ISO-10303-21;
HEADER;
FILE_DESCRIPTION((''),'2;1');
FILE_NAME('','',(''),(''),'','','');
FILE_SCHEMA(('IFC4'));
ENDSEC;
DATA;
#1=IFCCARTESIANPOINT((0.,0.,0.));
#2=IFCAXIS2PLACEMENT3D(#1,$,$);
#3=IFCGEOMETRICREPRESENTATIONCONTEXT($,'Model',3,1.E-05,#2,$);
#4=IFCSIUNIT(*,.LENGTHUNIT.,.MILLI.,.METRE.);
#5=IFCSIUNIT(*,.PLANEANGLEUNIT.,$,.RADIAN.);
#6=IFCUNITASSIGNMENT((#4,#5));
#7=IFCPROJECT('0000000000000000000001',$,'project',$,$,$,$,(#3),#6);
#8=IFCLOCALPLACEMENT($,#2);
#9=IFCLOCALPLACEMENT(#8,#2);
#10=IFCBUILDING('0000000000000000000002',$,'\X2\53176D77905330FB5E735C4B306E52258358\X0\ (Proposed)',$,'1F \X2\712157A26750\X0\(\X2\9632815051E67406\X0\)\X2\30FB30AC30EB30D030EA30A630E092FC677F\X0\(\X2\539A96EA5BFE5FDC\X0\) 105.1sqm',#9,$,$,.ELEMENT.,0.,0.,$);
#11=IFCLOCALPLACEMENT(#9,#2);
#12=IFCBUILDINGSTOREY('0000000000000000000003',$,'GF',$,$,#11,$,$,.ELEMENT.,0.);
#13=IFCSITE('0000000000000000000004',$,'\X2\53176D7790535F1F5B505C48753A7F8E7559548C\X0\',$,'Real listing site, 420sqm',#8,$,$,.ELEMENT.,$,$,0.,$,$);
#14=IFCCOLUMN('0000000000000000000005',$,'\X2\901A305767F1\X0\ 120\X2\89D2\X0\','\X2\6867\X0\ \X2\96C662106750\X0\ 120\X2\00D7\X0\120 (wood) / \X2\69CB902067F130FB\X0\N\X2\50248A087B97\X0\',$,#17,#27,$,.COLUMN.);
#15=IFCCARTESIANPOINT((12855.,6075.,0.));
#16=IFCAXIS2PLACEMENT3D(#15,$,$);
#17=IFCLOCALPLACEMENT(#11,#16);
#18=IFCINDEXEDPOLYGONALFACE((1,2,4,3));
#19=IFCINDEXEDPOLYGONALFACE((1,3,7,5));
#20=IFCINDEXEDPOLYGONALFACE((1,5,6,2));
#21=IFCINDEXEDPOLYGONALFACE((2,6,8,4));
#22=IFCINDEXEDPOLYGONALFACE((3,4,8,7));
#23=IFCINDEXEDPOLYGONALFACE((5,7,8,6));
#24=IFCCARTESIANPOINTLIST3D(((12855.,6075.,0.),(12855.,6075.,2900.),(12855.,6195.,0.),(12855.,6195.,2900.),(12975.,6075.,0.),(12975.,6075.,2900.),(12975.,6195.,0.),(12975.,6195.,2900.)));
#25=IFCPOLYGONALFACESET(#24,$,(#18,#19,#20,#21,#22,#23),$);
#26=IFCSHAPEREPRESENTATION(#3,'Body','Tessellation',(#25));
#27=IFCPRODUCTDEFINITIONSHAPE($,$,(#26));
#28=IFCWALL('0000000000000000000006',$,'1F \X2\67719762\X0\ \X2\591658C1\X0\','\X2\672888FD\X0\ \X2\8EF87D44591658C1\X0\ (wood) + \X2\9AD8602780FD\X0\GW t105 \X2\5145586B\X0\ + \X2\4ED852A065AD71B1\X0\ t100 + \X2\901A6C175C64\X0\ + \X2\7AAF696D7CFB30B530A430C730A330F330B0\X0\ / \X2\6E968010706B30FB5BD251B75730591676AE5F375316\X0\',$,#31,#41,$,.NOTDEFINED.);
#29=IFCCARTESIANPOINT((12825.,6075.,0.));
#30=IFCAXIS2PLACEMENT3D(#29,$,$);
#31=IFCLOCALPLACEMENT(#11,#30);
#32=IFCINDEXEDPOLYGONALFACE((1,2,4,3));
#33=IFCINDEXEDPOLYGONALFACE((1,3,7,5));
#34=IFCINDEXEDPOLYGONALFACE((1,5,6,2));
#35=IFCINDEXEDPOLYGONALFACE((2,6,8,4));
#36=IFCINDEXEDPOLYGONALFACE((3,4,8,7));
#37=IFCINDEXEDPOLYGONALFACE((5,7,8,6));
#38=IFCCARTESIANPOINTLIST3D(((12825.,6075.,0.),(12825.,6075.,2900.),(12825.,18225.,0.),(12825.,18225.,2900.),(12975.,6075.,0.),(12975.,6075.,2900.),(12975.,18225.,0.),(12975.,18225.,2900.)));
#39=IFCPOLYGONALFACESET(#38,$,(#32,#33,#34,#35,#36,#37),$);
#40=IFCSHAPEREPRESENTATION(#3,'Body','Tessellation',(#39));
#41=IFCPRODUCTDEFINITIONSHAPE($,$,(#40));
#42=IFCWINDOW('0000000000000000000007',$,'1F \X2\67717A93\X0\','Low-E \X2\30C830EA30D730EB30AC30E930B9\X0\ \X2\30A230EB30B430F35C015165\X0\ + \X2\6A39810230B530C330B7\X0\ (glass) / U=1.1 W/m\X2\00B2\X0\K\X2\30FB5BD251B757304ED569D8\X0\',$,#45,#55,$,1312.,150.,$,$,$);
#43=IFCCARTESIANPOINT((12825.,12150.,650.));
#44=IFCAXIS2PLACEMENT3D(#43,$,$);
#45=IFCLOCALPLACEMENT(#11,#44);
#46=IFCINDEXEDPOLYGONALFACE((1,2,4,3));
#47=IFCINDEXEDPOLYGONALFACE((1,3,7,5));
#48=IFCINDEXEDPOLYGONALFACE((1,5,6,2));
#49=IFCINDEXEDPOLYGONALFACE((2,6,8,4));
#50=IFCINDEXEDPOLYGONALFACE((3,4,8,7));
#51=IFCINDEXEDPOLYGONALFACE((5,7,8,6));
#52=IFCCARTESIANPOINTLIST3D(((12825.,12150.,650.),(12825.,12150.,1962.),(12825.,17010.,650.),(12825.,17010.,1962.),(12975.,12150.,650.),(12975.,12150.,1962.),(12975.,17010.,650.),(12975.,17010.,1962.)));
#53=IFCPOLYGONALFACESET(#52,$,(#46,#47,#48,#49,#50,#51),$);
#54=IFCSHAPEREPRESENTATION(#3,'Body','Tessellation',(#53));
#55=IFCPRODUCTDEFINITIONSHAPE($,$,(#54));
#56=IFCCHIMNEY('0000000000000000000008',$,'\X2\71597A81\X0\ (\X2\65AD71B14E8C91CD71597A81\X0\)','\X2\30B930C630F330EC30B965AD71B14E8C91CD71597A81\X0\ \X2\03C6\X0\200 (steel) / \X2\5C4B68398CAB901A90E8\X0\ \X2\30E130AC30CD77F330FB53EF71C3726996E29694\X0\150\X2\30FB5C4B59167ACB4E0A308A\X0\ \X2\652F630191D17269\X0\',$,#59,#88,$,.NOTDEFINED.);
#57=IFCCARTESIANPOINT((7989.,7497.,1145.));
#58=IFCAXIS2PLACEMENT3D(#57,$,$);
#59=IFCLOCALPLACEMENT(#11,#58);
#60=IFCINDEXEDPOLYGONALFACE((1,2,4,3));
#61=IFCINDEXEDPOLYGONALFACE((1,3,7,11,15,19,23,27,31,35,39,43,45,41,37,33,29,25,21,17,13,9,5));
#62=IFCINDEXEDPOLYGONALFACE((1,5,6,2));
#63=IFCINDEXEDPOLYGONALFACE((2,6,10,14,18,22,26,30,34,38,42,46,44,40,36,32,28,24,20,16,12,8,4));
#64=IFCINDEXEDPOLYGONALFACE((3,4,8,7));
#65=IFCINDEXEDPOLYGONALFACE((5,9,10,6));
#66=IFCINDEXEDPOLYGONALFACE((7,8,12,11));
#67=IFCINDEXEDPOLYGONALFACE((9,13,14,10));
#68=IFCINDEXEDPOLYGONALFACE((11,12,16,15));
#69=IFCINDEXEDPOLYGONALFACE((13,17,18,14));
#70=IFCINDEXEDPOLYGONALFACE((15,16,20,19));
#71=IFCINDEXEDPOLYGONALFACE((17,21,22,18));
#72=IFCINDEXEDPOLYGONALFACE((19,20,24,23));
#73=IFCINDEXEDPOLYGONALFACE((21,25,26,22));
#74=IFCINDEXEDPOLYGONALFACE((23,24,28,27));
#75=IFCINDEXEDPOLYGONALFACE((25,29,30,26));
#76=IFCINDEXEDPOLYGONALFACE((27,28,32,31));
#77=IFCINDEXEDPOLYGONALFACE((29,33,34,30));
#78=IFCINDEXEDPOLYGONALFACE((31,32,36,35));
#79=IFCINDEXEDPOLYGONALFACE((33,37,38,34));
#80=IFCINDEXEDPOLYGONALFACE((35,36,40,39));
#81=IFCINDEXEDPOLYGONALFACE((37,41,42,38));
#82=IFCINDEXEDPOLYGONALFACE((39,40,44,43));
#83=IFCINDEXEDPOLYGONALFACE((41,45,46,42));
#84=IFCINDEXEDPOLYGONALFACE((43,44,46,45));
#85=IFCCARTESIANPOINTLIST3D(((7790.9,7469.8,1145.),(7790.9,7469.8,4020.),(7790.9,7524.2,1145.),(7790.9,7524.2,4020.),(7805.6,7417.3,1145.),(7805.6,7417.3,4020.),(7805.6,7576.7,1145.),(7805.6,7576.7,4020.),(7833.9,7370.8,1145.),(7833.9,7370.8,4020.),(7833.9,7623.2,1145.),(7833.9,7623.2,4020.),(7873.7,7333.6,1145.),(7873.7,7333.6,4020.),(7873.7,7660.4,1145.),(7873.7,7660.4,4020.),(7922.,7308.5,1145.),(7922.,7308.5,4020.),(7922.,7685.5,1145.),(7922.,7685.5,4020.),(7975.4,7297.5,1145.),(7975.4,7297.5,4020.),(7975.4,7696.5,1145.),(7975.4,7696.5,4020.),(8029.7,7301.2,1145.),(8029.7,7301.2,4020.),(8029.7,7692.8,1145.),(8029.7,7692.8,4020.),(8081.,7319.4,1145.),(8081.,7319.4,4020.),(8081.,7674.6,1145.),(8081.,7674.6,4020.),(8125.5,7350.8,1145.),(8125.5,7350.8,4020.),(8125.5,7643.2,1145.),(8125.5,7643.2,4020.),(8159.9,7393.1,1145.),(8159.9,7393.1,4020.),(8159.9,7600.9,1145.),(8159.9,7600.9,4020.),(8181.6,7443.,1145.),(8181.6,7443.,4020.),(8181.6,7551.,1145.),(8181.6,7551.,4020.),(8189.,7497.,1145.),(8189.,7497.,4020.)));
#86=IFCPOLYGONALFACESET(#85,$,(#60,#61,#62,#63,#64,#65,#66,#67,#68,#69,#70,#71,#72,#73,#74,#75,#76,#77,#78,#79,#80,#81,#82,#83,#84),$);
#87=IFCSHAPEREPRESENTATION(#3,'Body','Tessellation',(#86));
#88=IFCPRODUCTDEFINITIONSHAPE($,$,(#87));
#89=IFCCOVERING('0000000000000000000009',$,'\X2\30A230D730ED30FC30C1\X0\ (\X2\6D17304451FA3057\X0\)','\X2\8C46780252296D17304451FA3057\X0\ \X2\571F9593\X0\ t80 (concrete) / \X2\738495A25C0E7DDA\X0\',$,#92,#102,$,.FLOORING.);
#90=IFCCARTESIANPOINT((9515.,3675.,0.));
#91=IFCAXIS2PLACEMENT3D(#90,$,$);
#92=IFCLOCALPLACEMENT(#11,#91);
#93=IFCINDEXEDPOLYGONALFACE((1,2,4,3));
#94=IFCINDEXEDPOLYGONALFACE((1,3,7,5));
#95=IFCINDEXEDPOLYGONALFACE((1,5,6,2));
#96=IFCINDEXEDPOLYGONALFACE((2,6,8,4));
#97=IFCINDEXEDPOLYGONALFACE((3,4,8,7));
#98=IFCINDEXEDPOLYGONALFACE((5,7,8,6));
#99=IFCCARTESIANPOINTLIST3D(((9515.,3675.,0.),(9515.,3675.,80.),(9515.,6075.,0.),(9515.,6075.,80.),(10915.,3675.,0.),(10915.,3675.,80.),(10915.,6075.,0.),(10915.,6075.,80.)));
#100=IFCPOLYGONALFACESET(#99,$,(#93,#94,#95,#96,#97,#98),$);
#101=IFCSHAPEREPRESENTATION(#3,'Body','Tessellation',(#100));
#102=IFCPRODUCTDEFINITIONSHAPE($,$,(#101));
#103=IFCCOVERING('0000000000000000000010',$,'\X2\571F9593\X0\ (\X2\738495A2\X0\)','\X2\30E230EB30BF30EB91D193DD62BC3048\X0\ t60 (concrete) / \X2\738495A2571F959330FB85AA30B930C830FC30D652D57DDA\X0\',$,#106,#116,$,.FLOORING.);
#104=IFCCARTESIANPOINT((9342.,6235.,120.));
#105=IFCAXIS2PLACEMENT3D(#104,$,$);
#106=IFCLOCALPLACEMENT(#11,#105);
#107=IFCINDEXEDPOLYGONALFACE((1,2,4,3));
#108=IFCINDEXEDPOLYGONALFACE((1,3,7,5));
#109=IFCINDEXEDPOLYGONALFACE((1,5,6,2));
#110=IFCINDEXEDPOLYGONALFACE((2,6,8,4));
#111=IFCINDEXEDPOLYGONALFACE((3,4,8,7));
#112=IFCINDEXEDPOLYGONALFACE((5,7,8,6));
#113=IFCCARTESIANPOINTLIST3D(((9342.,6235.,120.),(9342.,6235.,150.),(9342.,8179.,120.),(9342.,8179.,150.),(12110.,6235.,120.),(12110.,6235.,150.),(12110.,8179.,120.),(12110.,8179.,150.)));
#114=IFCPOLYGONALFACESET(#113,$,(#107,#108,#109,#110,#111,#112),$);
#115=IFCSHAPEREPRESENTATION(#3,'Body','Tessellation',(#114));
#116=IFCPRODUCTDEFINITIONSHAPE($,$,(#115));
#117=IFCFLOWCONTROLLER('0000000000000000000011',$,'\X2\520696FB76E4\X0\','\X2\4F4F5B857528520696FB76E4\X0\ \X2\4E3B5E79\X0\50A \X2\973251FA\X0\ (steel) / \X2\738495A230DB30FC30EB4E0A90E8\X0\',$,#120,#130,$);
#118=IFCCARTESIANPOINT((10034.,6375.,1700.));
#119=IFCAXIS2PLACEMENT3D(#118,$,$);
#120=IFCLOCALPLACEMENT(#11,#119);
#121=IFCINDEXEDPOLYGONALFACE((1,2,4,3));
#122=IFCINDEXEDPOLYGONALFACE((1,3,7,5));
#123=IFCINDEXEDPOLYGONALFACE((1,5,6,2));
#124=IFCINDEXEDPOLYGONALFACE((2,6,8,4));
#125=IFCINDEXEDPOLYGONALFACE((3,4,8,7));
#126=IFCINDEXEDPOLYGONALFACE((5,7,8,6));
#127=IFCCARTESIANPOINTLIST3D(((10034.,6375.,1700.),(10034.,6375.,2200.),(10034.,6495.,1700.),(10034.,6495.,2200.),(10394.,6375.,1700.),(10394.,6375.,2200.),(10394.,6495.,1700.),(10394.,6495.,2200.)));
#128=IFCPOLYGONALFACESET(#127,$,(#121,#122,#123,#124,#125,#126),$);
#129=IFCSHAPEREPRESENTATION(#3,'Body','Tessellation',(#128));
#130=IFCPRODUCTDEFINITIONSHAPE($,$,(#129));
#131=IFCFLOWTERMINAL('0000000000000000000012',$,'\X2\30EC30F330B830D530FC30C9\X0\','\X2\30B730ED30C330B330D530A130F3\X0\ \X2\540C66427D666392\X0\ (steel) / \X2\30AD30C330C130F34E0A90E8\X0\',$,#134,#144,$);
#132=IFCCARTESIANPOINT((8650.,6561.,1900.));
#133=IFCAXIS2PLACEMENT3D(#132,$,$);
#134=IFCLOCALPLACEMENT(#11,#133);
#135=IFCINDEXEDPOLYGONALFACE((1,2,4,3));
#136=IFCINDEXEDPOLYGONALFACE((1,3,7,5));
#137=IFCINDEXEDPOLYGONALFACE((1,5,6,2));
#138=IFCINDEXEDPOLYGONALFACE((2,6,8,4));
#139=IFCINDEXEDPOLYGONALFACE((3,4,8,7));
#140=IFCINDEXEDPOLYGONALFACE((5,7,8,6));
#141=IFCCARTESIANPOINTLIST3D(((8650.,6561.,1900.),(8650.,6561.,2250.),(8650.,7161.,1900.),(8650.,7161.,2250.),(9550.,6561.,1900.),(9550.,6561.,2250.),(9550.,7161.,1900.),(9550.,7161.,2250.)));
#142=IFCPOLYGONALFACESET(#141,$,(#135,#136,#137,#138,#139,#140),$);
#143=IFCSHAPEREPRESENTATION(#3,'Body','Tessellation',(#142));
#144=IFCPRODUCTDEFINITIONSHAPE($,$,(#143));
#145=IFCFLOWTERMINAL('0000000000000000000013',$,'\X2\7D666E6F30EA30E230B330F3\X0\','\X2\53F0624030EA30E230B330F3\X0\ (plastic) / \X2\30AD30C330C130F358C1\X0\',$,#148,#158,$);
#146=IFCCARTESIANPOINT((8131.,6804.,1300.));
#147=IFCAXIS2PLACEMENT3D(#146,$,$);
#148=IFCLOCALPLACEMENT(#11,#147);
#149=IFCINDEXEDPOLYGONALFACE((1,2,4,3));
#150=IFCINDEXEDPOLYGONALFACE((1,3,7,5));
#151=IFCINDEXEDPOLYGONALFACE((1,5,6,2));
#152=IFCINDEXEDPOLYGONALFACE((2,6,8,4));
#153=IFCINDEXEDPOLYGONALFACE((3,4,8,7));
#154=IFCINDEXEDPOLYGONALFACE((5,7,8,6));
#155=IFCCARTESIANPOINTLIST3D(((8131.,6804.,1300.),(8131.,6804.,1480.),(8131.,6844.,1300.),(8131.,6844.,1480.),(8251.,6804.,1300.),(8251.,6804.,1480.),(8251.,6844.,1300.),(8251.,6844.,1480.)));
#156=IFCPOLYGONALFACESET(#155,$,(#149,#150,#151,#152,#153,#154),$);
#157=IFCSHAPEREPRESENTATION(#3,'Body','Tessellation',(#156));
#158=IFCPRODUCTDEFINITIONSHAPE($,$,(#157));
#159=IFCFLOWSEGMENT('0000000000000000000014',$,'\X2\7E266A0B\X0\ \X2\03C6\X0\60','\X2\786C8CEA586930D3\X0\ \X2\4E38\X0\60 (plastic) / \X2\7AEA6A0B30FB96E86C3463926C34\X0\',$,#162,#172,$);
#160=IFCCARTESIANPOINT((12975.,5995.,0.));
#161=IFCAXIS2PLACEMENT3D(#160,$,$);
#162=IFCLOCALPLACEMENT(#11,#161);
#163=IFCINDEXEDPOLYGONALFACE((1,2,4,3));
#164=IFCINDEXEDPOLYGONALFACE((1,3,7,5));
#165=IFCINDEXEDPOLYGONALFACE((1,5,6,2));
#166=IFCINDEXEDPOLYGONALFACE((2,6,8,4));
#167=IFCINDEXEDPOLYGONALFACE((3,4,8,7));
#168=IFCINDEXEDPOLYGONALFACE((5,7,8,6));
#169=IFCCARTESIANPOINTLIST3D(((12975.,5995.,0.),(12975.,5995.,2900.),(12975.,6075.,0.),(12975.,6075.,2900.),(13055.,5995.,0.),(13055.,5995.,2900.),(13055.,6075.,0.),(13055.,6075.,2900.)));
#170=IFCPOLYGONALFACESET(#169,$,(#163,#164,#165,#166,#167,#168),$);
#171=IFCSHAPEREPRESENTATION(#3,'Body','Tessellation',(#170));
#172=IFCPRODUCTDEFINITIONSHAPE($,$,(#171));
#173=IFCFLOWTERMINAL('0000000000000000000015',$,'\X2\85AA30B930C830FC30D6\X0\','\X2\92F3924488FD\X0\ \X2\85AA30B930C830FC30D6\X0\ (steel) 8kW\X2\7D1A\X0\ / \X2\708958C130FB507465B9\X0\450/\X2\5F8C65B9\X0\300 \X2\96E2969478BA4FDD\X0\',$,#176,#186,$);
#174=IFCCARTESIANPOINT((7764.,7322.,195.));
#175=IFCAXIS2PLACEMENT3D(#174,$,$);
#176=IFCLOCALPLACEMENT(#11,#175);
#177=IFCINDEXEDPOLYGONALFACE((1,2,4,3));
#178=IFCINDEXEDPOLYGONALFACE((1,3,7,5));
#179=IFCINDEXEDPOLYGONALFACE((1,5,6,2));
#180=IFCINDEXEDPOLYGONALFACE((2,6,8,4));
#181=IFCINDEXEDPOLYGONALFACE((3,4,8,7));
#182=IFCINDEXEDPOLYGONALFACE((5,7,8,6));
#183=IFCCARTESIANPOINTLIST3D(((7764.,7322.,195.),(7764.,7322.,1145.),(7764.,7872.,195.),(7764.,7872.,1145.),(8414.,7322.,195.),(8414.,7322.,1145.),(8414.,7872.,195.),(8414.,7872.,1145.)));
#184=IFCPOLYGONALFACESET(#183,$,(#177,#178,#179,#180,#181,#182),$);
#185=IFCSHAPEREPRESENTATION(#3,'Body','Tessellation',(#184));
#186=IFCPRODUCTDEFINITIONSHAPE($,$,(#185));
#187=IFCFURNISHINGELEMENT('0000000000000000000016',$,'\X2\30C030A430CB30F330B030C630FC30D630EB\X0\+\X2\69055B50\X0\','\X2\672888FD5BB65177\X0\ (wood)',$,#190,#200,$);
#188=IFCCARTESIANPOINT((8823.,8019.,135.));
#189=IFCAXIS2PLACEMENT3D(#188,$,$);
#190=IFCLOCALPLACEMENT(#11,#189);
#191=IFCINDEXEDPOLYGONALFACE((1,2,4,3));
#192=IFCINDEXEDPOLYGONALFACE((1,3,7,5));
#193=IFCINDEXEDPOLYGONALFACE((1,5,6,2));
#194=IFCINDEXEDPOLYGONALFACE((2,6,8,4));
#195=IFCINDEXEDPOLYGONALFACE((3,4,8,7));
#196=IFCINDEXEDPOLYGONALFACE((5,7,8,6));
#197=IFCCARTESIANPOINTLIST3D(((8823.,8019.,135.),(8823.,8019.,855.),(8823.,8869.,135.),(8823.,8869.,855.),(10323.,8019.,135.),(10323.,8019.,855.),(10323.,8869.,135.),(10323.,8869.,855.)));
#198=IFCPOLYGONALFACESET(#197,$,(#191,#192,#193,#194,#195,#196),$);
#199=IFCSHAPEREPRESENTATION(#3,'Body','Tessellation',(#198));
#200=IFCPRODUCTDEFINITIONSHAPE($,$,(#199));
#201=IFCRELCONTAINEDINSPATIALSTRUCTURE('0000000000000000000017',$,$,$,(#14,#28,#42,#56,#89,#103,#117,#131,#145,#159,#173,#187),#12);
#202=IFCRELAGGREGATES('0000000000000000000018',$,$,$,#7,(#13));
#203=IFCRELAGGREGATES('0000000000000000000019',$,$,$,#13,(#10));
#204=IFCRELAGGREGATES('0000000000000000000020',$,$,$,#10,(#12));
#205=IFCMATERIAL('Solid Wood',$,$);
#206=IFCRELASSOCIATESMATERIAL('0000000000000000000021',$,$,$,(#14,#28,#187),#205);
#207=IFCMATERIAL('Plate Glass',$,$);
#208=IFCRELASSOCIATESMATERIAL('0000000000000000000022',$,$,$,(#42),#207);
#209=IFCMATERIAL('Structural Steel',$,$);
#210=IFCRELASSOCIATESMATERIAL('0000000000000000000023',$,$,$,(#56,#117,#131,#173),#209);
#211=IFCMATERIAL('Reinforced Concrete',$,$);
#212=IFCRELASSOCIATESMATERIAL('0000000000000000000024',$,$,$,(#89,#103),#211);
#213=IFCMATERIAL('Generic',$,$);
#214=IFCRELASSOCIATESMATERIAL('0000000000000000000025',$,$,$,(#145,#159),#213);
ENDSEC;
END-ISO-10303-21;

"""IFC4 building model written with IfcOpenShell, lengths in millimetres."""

from ifc_helpers import new_model, si_unit, frame, frame_2d, origin, origin_2d, place, context, project, spatial, rectangle, circle, extrude, material, element, fill, save


model = new_model("IFC4")

# Units and contexts
model_context = context("Model", 3, precision=1e-05, world=origin())
ifc_project = project(units=[si_unit("LENGTHUNIT", "METRE", prefix="MILLI"), si_unit("PLANEANGLEUNIT", "RADIAN")], contexts=[model_context])

# Site, building, storey
site_placement = place(None, origin())
site = spatial("IfcSite", under=ifc_project, at=site_placement, Name="北海道弟子屈町美留和", ObjectType="Real listing site, 420sqm", CompositionType="ELEMENT", RefElevation=0.0)
building_placement = place(site_placement, origin())
building = spatial("IfcBuilding", under=site, at=building_placement, Name="北海道・平屋の別荘 (Proposed)", ObjectType="1F 無垢材(防腐処理)・ガルバリウム鋼板(厚雪対応) 105.1sqm", CompositionType="ELEMENT", ElevationOfRefHeight=0.0, ElevationOfTerrain=0.0)
storey_placement = place(building_placement, origin())
storey = spatial("IfcBuildingStorey", under=building, at=storey_placement, Name="GF", CompositionType="ELEMENT", Elevation=0.0)

# Column
ifc_material_1 = material(Name="Solid Wood")
column_1_placement = place(storey_placement, frame((12855.0, 6075.0, 0.0)))
element("IfcColumn", 1, at=column_1_placement, inside=storey, material=ifc_material_1, Name="通し柱 120角", Description="桧 集成材 120×120 (wood) / 構造柱・N値計算", PredefinedType="COLUMN", context=model_context, shape_type="SweptSolid", body=[
    extrude(rectangle(XDim=120.0, YDim=120.0, at=frame_2d((60.0, 60.0))), frame((12855.0, 6075.0, 0.0)), (0.0, 0.0, 1.0), 2900.0),
])

# Wall, opening, window
wall_1_placement = place(storey_placement, frame((12825.0, 6075.0, 0.0)))
wall_1 = element("IfcWall", 2, at=wall_1_placement, inside=storey, material=ifc_material_1, Name="1F 東面 外壁", Description="木製 軸組外壁 (wood) + 高性能GW t105 充填 + 付加断熱 t100 + 通気層 + 窯業系サイディング / 準耐火・寒冷地外皮強化", PredefinedType="NOTDEFINED", context=model_context, shape_type="SweptSolid", body=[
    extrude(rectangle(XDim=150.0, YDim=12150.0, at=frame_2d((75.0, 6075.0))), frame((12825.0, 6075.0, 0.0)), (0.0, 0.0, 1.0), 2900.0),
])
opening_placement = place(storey_placement, frame((12825.0, 12150.0, 650.0)))
opening = element("IfcOpeningElement", 3, at=opening_placement, cuts=wall_1, PredefinedType="NOTDEFINED", context=model_context, shape_type="SweptSolid", body=[
    extrude(rectangle(XDim=150.0, YDim=4860.0, at=frame_2d((75.0, 2430.0))), frame((12825.0, 12150.0, 650.0)), (0.0, 0.0, 1.0), 1312.0),
])
ifc_material_2 = material(Name="Plate Glass")
window_placement = place(storey_placement, frame((12825.0, 12150.0, 650.0)))
window = element("IfcWindow", 4, at=window_placement, inside=storey, material=ifc_material_2, Name="1F 東窓", Description="Low-E トリプルガラス アルゴン封入 + 樹脂サッシ (glass) / U=1.1 W/m²K・寒冷地仕様", OverallHeight=1312.0, OverallWidth=150.0, context=model_context, shape_type="SweptSolid", body=[
    extrude(rectangle(XDim=150.0, YDim=4860.0, at=frame_2d((75.0, 2430.0))), frame((12825.0, 12150.0, 650.0)), (0.0, 0.0, 1.0), 1312.0),
])
fill(opening, window)

# Chimney
ifc_material_3 = material(Name="Structural Steel")
chimney_placement = place(storey_placement, frame((7989.0, 7497.0, 1145.0)))
element("IfcChimney", 5, at=chimney_placement, inside=storey, material=ifc_material_3, Name="煙突 (断熱二重煙突)", Description="ステンレス断熱二重煙突 φ200 (steel) / 屋根貫通部 メガネ石・可燃物離隔150・屋外立上り 支持金物", PredefinedType="NOTDEFINED", context=model_context, shape_type="SweptSolid", body=[
    extrude(circle(Radius=200.0, at=origin_2d()), frame((7989.0, 7497.0, 1145.0)), (0.0, 0.0, 1.0), 2875.0),
])

# Coverings
ifc_material_4 = material(Name="Reinforced Concrete")
covering_1_placement = place(storey_placement, frame((9515.0, 3675.0, 0.0)))
element("IfcCovering", 6, at=covering_1_placement, inside=storey, material=ifc_material_4, Name="アプローチ (洗い出し)", Description="豆砂利洗い出し 土間 t80 (concrete) / 玄関導線", PredefinedType="FLOORING", context=model_context, shape_type="SweptSolid", body=[
    extrude(rectangle(XDim=1400.0, YDim=2400.0, at=frame_2d((700.0, 1200.0))), frame((9515.0, 3675.0, 0.0)), (0.0, 0.0, 1.0), 80.0),
])
covering_2_placement = place(storey_placement, frame((9342.0, 6235.0, 120.0)))
element("IfcCovering", 7, at=covering_2_placement, inside=storey, material=ifc_material_4, Name="土間 (玄関)", Description="モルタル金鏝押え t60 (concrete) / 玄関土間・薪ストーブ動線", PredefinedType="FLOORING", context=model_context, shape_type="SweptSolid", body=[
    extrude(rectangle(XDim=2768.0, YDim=1944.0, at=frame_2d((1384.0, 972.0))), frame((9342.0, 6235.0, 120.0)), (0.0, 0.0, 1.0), 30.0),
])

# Flow controller
flow_controller_placement = place(storey_placement, frame((10034.0, 6375.0, 1700.0)))
element("IfcFlowController", 8, at=flow_controller_placement, inside=storey, material=ifc_material_3, Name="分電盤", Description="住宅用分電盤 主幹50A 露出 (steel) / 玄関ホール上部", context=model_context, shape_type="SweptSolid", body=[
    extrude(rectangle(XDim=360.0, YDim=120.0, at=frame_2d((180.0, 60.0))), frame((10034.0, 6375.0, 1700.0)), (0.0, 0.0, 1.0), 500.0),
])

# Flow terminals
flow_terminal_1_placement = place(storey_placement, frame((8650.0, 6561.0, 1900.0)))
element("IfcFlowTerminal", 9, at=flow_terminal_1_placement, inside=storey, material=ifc_material_3, Name="レンジフード", Description="シロッコファン 同時給排 (steel) / キッチン上部", context=model_context, shape_type="SweptSolid", body=[
    extrude(rectangle(XDim=900.0, YDim=600.0, at=frame_2d((450.0, 300.0))), frame((8650.0, 6561.0, 1900.0)), (0.0, 0.0, 1.0), 350.0),
])
ifc_material_5 = material(Name="Generic")
flow_terminal_2_placement = place(storey_placement, frame((8131.0, 6804.0, 1300.0)))
element("IfcFlowTerminal", 10, at=flow_terminal_2_placement, inside=storey, material=ifc_material_5, Name="給湯リモコン", Description="台所リモコン (plastic) / キッチン壁", context=model_context, shape_type="SweptSolid", body=[
    extrude(rectangle(XDim=120.0, YDim=40.0, at=frame_2d((60.0, 20.0))), frame((8131.0, 6804.0, 1300.0)), (0.0, 0.0, 1.0), 180.0),
])

# Flow segment
flow_segment_placement = place(storey_placement, frame((12975.0, 5995.0, 0.0)))
element("IfcFlowSegment", 11, at=flow_segment_placement, inside=storey, material=ifc_material_5, Name="縦樋 φ60", Description="硬質塩ビ 丸60 (plastic) / 竪樋・雨水排水", context=model_context, shape_type="SweptSolid", body=[
    extrude(rectangle(XDim=80.0, YDim=80.0, at=frame_2d((40.0, 40.0))), frame((12975.0, 5995.0, 0.0)), (0.0, 0.0, 1.0), 2900.0),
])

# Flow terminal
flow_terminal_3_placement = place(storey_placement, frame((7764.0, 7322.0, 195.0)))
element("IfcFlowTerminal", 12, at=flow_terminal_3_placement, inside=storey, material=ifc_material_3, Name="薪ストーブ", Description="鋳鉄製 薪ストーブ (steel) 8kW級 / 炉壁・側方450/後方300 離隔確保", context=model_context, shape_type="SweptSolid", body=[
    extrude(rectangle(XDim=650.0, YDim=550.0, at=frame_2d((325.0, 275.0))), frame((7764.0, 7322.0, 195.0)), (0.0, 0.0, 1.0), 950.0),
])

# Furnishing element
furnishing_1_placement = place(storey_placement, frame((8823.0, 8019.0, 135.0)))
element("IfcFurnishingElement", 13, at=furnishing_1_placement, inside=storey, material=ifc_material_1, Name="ダイニングテーブル+椅子", Description="木製家具 (wood)", context=model_context, shape_type="SweptSolid", body=[
    extrude(rectangle(XDim=1500.0, YDim=850.0, at=frame_2d((750.0, 425.0))), frame((8823.0, 8019.0, 135.0)), (0.0, 0.0, 1.0), 720.0),
])

save(model, "model.ifc")
